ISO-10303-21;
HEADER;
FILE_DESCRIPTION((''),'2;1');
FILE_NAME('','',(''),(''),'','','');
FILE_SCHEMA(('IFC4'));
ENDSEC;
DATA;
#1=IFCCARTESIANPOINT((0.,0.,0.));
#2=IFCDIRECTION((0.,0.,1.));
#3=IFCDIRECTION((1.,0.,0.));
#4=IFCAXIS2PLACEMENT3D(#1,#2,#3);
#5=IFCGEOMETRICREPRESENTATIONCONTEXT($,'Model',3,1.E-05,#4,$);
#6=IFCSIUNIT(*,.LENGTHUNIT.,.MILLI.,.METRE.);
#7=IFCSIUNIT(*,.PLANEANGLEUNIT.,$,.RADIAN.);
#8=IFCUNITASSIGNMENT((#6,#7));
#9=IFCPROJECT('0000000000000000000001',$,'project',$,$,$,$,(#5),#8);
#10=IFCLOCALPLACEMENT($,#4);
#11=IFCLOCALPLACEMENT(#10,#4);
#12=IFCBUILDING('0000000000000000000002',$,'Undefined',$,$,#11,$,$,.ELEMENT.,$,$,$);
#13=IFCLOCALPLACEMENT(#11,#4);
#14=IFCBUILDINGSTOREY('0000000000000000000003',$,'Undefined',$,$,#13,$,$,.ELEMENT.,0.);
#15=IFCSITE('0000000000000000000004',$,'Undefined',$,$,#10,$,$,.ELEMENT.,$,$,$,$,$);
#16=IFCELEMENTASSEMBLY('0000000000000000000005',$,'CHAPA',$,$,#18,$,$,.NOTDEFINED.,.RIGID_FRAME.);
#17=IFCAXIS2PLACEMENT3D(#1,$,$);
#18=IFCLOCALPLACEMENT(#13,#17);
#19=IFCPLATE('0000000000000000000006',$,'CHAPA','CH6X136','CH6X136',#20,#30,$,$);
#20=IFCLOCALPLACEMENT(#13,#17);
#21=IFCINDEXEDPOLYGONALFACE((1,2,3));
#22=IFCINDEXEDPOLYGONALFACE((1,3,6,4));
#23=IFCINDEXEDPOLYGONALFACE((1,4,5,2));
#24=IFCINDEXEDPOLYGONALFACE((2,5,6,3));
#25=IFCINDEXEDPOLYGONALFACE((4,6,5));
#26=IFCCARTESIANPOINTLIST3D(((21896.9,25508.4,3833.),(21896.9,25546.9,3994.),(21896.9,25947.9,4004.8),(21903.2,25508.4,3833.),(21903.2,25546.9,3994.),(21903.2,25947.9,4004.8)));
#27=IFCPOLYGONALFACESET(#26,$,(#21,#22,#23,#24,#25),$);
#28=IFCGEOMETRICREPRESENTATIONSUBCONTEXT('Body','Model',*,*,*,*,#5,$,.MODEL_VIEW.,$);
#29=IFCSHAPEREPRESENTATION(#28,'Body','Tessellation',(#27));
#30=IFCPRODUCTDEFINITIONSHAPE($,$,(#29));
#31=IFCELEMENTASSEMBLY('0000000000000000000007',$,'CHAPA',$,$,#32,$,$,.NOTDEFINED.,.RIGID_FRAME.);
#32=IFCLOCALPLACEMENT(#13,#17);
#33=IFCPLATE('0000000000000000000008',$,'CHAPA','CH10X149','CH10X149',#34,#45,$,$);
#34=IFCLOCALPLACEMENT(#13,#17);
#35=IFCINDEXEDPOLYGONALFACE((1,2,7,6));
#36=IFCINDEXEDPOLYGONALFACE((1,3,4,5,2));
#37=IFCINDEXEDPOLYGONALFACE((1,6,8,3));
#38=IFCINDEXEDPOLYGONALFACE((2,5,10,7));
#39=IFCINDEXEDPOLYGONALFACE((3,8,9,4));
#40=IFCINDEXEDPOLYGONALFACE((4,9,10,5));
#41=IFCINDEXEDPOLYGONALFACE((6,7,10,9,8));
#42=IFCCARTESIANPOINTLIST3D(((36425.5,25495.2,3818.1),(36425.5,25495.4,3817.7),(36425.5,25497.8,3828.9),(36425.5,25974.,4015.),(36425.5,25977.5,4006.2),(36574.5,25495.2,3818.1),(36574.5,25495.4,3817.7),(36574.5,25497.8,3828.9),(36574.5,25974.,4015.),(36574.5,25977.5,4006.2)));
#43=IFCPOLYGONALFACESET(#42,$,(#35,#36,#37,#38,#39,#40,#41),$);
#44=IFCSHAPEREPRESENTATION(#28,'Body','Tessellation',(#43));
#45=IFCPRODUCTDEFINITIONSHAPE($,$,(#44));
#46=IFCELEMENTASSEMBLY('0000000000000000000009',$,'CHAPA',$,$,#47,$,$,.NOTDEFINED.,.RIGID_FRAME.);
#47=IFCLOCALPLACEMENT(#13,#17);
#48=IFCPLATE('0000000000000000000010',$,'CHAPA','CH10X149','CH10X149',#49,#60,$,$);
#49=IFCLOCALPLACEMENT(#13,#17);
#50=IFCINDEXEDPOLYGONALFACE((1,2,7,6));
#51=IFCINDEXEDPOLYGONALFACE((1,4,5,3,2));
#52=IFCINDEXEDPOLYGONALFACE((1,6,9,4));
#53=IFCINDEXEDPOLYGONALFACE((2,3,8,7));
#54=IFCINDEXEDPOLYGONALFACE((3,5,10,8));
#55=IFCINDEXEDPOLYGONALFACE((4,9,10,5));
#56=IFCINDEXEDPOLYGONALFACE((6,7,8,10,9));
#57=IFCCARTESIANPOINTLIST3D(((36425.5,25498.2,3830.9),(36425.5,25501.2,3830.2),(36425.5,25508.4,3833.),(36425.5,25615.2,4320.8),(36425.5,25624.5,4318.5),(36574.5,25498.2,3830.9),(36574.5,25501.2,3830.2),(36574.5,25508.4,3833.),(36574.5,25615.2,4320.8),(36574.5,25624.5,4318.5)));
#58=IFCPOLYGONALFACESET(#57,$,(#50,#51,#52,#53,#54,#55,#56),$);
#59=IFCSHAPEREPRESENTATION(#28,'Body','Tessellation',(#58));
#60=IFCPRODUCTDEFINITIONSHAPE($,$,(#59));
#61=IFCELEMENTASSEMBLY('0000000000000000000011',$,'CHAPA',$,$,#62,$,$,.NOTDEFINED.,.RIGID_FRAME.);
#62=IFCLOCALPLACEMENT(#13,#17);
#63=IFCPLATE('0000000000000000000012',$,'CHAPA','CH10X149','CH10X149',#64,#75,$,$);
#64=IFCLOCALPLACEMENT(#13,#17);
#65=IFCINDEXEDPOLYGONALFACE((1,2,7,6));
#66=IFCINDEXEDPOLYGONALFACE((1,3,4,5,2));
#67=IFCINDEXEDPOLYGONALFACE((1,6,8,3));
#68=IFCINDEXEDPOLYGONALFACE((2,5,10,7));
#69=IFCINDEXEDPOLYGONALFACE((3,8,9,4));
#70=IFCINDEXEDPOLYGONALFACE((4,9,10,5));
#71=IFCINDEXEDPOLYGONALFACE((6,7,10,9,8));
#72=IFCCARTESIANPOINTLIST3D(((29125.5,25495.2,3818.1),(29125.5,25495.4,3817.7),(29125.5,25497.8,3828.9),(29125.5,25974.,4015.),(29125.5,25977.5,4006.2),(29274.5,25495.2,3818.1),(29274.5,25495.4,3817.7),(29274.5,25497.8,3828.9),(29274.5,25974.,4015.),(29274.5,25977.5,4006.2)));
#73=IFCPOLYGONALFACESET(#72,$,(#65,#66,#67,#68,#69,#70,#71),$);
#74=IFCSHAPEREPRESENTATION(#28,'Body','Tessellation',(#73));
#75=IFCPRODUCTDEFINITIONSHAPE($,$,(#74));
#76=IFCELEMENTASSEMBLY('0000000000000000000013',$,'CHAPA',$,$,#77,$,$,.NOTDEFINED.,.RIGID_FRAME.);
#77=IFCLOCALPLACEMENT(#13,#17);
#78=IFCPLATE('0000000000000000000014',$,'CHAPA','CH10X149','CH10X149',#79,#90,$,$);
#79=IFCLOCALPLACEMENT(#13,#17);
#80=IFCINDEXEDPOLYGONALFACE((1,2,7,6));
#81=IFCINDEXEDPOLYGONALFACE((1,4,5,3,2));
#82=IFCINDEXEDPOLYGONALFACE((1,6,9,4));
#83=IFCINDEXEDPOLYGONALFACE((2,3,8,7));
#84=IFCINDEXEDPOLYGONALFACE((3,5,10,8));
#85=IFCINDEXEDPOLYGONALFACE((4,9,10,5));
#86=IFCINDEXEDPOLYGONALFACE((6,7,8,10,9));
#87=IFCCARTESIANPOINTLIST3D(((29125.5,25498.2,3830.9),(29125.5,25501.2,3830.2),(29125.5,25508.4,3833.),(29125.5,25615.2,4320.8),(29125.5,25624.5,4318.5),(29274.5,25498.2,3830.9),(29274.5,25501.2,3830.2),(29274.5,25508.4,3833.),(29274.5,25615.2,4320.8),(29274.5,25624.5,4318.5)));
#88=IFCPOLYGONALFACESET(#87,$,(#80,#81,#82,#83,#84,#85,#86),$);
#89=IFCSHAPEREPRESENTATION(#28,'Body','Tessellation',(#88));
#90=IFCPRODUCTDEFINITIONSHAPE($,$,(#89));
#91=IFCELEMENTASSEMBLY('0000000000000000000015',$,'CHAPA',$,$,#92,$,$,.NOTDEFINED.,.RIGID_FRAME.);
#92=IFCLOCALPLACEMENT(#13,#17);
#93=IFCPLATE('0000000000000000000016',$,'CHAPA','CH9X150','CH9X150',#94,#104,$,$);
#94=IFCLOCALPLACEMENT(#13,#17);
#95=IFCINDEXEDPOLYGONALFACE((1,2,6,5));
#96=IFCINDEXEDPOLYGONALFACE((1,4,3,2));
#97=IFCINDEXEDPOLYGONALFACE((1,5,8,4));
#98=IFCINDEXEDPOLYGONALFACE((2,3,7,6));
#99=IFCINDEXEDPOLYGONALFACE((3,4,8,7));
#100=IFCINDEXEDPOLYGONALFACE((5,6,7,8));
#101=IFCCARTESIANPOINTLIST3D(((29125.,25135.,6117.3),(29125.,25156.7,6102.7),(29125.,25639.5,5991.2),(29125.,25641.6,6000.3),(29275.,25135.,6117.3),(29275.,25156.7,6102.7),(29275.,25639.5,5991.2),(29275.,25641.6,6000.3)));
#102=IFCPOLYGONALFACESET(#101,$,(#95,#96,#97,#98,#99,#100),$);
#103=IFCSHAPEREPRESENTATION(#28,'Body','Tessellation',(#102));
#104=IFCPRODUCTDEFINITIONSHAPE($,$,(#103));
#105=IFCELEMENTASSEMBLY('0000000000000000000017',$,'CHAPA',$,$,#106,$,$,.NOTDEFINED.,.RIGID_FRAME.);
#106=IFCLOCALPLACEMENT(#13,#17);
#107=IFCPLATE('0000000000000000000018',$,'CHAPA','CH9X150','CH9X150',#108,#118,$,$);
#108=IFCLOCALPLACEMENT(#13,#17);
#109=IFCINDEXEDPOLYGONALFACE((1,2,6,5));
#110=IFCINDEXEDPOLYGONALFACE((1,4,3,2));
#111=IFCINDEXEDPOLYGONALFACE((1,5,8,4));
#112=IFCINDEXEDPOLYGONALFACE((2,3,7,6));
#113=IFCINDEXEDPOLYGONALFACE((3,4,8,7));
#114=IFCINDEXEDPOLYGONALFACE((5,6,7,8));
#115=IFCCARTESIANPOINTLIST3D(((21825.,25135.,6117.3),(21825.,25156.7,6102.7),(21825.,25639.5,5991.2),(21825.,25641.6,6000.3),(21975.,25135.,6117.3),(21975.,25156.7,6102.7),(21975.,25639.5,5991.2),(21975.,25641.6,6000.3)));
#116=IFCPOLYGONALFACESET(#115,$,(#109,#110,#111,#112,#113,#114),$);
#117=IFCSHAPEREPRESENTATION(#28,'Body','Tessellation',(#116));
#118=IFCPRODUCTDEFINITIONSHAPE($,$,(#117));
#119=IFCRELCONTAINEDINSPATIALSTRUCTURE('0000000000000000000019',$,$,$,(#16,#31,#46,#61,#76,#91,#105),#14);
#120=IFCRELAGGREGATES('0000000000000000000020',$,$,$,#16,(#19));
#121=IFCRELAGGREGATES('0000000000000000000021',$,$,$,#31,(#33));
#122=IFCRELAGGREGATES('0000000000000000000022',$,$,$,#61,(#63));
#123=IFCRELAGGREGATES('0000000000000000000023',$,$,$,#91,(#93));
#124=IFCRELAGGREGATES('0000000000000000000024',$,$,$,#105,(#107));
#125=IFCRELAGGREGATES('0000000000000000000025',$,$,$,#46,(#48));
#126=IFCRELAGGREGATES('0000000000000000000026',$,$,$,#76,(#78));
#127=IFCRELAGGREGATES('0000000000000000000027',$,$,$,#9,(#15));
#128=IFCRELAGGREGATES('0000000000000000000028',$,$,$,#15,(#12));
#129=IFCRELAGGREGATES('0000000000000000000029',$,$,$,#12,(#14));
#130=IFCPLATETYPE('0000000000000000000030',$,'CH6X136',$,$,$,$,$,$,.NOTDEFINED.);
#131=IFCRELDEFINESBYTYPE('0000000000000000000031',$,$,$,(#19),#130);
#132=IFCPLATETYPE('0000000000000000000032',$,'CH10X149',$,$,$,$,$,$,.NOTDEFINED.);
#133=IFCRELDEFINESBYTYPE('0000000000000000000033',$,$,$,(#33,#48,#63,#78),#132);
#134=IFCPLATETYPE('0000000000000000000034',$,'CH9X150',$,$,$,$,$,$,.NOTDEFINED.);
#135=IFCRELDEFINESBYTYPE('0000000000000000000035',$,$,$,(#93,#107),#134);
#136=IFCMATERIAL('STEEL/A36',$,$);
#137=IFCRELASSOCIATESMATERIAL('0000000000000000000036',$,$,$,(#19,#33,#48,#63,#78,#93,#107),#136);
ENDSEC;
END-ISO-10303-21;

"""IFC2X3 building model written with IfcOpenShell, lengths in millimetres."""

from ifc_helpers import new_model, si_unit, frame, origin_with_axes, place, context, subcontext, project, spatial, polyline, outline, extrude, clip, halfspace, material, type_object, element, aggregate, save


model = new_model("IFC2X3")

# Units and contexts
model_context = context("Model", 3, precision=1e-05, world=origin_with_axes())
body_context = subcontext(model_context, "Body", "Model", "MODEL_VIEW")
ifc_project = project(units=[si_unit("LENGTHUNIT", "METRE", prefix="MILLI"), si_unit("PLANEANGLEUNIT", "RADIAN")], contexts=[model_context])

# Site, building, storey
site_placement = place(None, origin_with_axes())
site = spatial("IfcSite", under=ifc_project, at=site_placement, Name="Undefined", CompositionType="ELEMENT")
building_placement = place(site_placement, origin_with_axes())
building = spatial("IfcBuilding", under=site, at=building_placement, Name="Undefined", CompositionType="ELEMENT")
storey_placement = place(building_placement, origin_with_axes())
storey = spatial("IfcBuildingStorey", under=building, at=storey_placement, Name="Undefined", CompositionType="ELEMENT", Elevation=0.0)

# Shared definitions
ifc_material_1 = material(Name="STEEL/A36")

# Element assemblies, plates
plate_type_1 = type_object("IfcPlateType", Name="CH6X136", PredefinedType="NOTDEFINED")
assembly_1_placement = place(storey_placement, origin_with_axes())
assembly_1 = element("IfcElementAssembly", 1, at=assembly_1_placement, inside=storey, Name="CHAPA", AssemblyPlace="NOTDEFINED", PredefinedType="RIGID_FRAME")
plate_1_placement = place(assembly_1_placement, frame((21900.0, 25546.9, 3994.0), z_axis=(-1.0, 0.0, 0.0), x_axis=(0.0, 0.999636, 0.026972)))
plate_1 = element("IfcPlate", 2, at=plate_1_placement, type_object=plate_type_1, material=ifc_material_1, Name="CHAPA", Description="CH6X136", ObjectType="CH6X136", context=body_context, shape_type="SweptSolid", body=[
    extrude(outline(polyline([(0.0, 0.0), (401.1, 0.0), (-42.8, 159.9), (0.0, 0.0)])), frame((0.0, 0.0, -3.1), z_axis=(0.0, 0.0, 1.0), x_axis=(1.0, 0.0, 0.0)), (0.0, 0.0, 1.0), 6.3),
])
aggregate(assembly_1, [plate_1])
assembly_2_placement = place(storey_placement, origin_with_axes())
assembly_2 = element("IfcElementAssembly", 3, at=assembly_2_placement, inside=storey, Name="CHAPA", AssemblyPlace="NOTDEFINED", PredefinedType="RIGID_FRAME")
plate_type_2 = type_object("IfcPlateType", Name="CH10X149", PredefinedType="NOTDEFINED")
plate_2_placement = place(assembly_2_placement, frame((36425.5, 25975.7, 4010.6), z_axis=(0.0, 0.364063, -0.931374), x_axis=(1.0, 0.0, 0.0)))
plate_2 = element("IfcPlate", 4, at=plate_2_placement, type_object=plate_type_2, material=ifc_material_1, Name="CHAPA", Description="CH10X149", ObjectType="CH10X149", context=body_context, shape_type="Clipping", body=[
    clip(extrude(outline(polyline([(0.0, 0.0), (149.0, 0.0), (149.0, 517.6), (0.0, 517.6), (0.0, 0.0)])), frame((0.0, 0.0, -4.8), z_axis=(0.0, 0.0, 1.0), x_axis=(1.0, 0.0, 0.0)), (0.0, 0.0, 1.0), 9.5), halfspace(frame((149.0, 517.9, 4.7), z_axis=(0.0, 0.821204, -0.570634), x_axis=(-1.0, 0.0, 0.0)), False)),
])
aggregate(assembly_2, [plate_2])
assembly_3_placement = place(storey_placement, origin_with_axes())
assembly_3 = element("IfcElementAssembly", 5, at=assembly_3_placement, inside=storey, Name="CHAPA", AssemblyPlace="NOTDEFINED", PredefinedType="RIGID_FRAME")
plate_3_placement = place(assembly_3_placement, frame((36425.5, 25619.9, 4319.6), z_axis=(0.0, 0.972612, -0.232434), x_axis=(1.0, 0.000007, 0.000031)))
plate_3 = element("IfcPlate", 6, at=plate_3_placement, type_object=plate_type_2, material=ifc_material_1, Name="CHAPA", Description="CH10X149", ObjectType="CH10X149", context=body_context, shape_type="Clipping", body=[
    clip(extrude(outline(polyline([(0.0, 0.0), (70.9, 0.0), (149.0, 0.0), (149.0, 503.6), (0.0, 503.6), (0.0, 0.0)])), frame((0.0, 0.0, -4.8), z_axis=(0.0, 0.0, 1.0), x_axis=(1.0, 0.0, 0.0)), (0.0, 0.0, 1.0), 9.5), halfspace(frame((70.9, 499.2, 4.7), z_axis=(-0.000026, 0.821245, 0.570575), x_axis=(-1.0, -0.000032, 0.0)), False)),
])
assembly_4_placement = place(storey_placement, origin_with_axes())
assembly_4 = element("IfcElementAssembly", 7, at=assembly_4_placement, inside=storey, Name="CHAPA", AssemblyPlace="NOTDEFINED", PredefinedType="RIGID_FRAME")
plate_4_placement = place(assembly_4_placement, frame((29125.5, 25975.7, 4010.6), z_axis=(0.0, 0.364063, -0.931374), x_axis=(1.0, 0.0, 0.0)))
plate_4 = element("IfcPlate", 8, at=plate_4_placement, type_object=plate_type_2, material=ifc_material_1, Name="CHAPA", Description="CH10X149", ObjectType="CH10X149", context=body_context, shape_type="Clipping", body=[
    clip(extrude(outline(polyline([(0.0, 0.0), (149.0, 0.0), (149.0, 517.6), (0.0, 517.6), (0.0, 0.0)])), frame((0.0, 0.0, -4.8), z_axis=(0.0, 0.0, 1.0), x_axis=(1.0, 0.0, 0.0)), (0.0, 0.0, 1.0), 9.5), halfspace(frame((149.0, 517.9, 4.7), z_axis=(0.0, 0.821204, -0.570634), x_axis=(-1.0, 0.0, 0.0)), False)),
])
aggregate(assembly_4, [plate_4])
assembly_5_placement = place(storey_placement, origin_with_axes())
assembly_5 = element("IfcElementAssembly", 9, at=assembly_5_placement, inside=storey, Name="CHAPA", AssemblyPlace="NOTDEFINED", PredefinedType="RIGID_FRAME")
plate_5_placement = place(assembly_5_placement, frame((29125.5, 25619.9, 4319.6), z_axis=(0.0, 0.972612, -0.232434), x_axis=(1.0, 0.000007, 0.000031)))
plate_5 = element("IfcPlate", 10, at=plate_5_placement, type_object=plate_type_2, material=ifc_material_1, Name="CHAPA", Description="CH10X149", ObjectType="CH10X149", context=body_context, shape_type="Clipping", body=[
    clip(extrude(outline(polyline([(0.0, 0.0), (70.9, 0.0), (149.0, 0.0), (149.0, 503.6), (0.0, 503.6), (0.0, 0.0)])), frame((0.0, 0.0, -4.8), z_axis=(0.0, 0.0, 1.0), x_axis=(1.0, 0.0, 0.0)), (0.0, 0.0, 1.0), 9.5), halfspace(frame((70.9, 499.2, 4.7), z_axis=(-0.000026, 0.821245, 0.570575), x_axis=(-1.0, -0.000032, 0.0)), False)),
])
assembly_6_placement = place(storey_placement, origin_with_axes())
assembly_6 = element("IfcElementAssembly", 11, at=assembly_6_placement, inside=storey, Name="CHAPA", AssemblyPlace="NOTDEFINED", PredefinedType="RIGID_FRAME")
plate_type_3 = type_object("IfcPlateType", Name="CH9X150", PredefinedType="NOTDEFINED")
plate_6_placement = place(assembly_6_placement, frame((29275.0, 25640.6, 5995.7), z_axis=(0.0, -0.225124, -0.97433), x_axis=(0.0, -0.97433, 0.225124)))
plate_6 = element("IfcPlate", 12, at=plate_6_placement, type_object=plate_type_3, material=ifc_material_1, Name="CHAPA", Description="CH9X150", ObjectType="CH9X150", context=body_context, shape_type="Clipping", body=[
    clip(extrude(outline(polyline([(0.0, 0.0), (520.0, 0.0), (520.0, 150.0), (0.0, 150.0), (0.0, 0.0)])), frame((0.0, 0.0, -4.7), z_axis=(0.0, 0.0, 1.0), x_axis=(1.0, 0.0, 0.0)), (0.0, 0.0, 1.0), 9.3), halfspace(frame((520.0, -500.0, -4.7), z_axis=(0.354778, 0.0, 0.934951), x_axis=(-0.934951, 0.0, 0.354778)), False)),
])
aggregate(assembly_6, [plate_6])
assembly_7_placement = place(storey_placement, origin_with_axes())
assembly_7 = element("IfcElementAssembly", 13, at=assembly_7_placement, inside=storey, Name="CHAPA", AssemblyPlace="NOTDEFINED", PredefinedType="RIGID_FRAME")
plate_7_placement = place(assembly_7_placement, frame((21975.0, 25640.6, 5995.7), z_axis=(0.0, -0.225124, -0.97433), x_axis=(0.0, -0.97433, 0.225124)))
plate_7 = element("IfcPlate", 14, at=plate_7_placement, type_object=plate_type_3, material=ifc_material_1, Name="CHAPA", Description="CH9X150", ObjectType="CH9X150", context=body_context, shape_type="Clipping", body=[
    clip(extrude(outline(polyline([(0.0, 0.0), (520.0, 0.0), (520.0, 150.0), (0.0, 150.0), (0.0, 0.0)])), frame((0.0, 0.0, -4.7), z_axis=(0.0, 0.0, 1.0), x_axis=(1.0, 0.0, 0.0)), (0.0, 0.0, 1.0), 9.3), halfspace(frame((520.0, -500.0, -4.7), z_axis=(0.354778, 0.0, 0.934951), x_axis=(-0.934951, 0.0, 0.354778)), False)),
])
aggregate(assembly_7, [plate_7])

aggregate(assembly_3, [plate_3])
aggregate(assembly_5, [plate_5])

save(model, "model.ifc")
